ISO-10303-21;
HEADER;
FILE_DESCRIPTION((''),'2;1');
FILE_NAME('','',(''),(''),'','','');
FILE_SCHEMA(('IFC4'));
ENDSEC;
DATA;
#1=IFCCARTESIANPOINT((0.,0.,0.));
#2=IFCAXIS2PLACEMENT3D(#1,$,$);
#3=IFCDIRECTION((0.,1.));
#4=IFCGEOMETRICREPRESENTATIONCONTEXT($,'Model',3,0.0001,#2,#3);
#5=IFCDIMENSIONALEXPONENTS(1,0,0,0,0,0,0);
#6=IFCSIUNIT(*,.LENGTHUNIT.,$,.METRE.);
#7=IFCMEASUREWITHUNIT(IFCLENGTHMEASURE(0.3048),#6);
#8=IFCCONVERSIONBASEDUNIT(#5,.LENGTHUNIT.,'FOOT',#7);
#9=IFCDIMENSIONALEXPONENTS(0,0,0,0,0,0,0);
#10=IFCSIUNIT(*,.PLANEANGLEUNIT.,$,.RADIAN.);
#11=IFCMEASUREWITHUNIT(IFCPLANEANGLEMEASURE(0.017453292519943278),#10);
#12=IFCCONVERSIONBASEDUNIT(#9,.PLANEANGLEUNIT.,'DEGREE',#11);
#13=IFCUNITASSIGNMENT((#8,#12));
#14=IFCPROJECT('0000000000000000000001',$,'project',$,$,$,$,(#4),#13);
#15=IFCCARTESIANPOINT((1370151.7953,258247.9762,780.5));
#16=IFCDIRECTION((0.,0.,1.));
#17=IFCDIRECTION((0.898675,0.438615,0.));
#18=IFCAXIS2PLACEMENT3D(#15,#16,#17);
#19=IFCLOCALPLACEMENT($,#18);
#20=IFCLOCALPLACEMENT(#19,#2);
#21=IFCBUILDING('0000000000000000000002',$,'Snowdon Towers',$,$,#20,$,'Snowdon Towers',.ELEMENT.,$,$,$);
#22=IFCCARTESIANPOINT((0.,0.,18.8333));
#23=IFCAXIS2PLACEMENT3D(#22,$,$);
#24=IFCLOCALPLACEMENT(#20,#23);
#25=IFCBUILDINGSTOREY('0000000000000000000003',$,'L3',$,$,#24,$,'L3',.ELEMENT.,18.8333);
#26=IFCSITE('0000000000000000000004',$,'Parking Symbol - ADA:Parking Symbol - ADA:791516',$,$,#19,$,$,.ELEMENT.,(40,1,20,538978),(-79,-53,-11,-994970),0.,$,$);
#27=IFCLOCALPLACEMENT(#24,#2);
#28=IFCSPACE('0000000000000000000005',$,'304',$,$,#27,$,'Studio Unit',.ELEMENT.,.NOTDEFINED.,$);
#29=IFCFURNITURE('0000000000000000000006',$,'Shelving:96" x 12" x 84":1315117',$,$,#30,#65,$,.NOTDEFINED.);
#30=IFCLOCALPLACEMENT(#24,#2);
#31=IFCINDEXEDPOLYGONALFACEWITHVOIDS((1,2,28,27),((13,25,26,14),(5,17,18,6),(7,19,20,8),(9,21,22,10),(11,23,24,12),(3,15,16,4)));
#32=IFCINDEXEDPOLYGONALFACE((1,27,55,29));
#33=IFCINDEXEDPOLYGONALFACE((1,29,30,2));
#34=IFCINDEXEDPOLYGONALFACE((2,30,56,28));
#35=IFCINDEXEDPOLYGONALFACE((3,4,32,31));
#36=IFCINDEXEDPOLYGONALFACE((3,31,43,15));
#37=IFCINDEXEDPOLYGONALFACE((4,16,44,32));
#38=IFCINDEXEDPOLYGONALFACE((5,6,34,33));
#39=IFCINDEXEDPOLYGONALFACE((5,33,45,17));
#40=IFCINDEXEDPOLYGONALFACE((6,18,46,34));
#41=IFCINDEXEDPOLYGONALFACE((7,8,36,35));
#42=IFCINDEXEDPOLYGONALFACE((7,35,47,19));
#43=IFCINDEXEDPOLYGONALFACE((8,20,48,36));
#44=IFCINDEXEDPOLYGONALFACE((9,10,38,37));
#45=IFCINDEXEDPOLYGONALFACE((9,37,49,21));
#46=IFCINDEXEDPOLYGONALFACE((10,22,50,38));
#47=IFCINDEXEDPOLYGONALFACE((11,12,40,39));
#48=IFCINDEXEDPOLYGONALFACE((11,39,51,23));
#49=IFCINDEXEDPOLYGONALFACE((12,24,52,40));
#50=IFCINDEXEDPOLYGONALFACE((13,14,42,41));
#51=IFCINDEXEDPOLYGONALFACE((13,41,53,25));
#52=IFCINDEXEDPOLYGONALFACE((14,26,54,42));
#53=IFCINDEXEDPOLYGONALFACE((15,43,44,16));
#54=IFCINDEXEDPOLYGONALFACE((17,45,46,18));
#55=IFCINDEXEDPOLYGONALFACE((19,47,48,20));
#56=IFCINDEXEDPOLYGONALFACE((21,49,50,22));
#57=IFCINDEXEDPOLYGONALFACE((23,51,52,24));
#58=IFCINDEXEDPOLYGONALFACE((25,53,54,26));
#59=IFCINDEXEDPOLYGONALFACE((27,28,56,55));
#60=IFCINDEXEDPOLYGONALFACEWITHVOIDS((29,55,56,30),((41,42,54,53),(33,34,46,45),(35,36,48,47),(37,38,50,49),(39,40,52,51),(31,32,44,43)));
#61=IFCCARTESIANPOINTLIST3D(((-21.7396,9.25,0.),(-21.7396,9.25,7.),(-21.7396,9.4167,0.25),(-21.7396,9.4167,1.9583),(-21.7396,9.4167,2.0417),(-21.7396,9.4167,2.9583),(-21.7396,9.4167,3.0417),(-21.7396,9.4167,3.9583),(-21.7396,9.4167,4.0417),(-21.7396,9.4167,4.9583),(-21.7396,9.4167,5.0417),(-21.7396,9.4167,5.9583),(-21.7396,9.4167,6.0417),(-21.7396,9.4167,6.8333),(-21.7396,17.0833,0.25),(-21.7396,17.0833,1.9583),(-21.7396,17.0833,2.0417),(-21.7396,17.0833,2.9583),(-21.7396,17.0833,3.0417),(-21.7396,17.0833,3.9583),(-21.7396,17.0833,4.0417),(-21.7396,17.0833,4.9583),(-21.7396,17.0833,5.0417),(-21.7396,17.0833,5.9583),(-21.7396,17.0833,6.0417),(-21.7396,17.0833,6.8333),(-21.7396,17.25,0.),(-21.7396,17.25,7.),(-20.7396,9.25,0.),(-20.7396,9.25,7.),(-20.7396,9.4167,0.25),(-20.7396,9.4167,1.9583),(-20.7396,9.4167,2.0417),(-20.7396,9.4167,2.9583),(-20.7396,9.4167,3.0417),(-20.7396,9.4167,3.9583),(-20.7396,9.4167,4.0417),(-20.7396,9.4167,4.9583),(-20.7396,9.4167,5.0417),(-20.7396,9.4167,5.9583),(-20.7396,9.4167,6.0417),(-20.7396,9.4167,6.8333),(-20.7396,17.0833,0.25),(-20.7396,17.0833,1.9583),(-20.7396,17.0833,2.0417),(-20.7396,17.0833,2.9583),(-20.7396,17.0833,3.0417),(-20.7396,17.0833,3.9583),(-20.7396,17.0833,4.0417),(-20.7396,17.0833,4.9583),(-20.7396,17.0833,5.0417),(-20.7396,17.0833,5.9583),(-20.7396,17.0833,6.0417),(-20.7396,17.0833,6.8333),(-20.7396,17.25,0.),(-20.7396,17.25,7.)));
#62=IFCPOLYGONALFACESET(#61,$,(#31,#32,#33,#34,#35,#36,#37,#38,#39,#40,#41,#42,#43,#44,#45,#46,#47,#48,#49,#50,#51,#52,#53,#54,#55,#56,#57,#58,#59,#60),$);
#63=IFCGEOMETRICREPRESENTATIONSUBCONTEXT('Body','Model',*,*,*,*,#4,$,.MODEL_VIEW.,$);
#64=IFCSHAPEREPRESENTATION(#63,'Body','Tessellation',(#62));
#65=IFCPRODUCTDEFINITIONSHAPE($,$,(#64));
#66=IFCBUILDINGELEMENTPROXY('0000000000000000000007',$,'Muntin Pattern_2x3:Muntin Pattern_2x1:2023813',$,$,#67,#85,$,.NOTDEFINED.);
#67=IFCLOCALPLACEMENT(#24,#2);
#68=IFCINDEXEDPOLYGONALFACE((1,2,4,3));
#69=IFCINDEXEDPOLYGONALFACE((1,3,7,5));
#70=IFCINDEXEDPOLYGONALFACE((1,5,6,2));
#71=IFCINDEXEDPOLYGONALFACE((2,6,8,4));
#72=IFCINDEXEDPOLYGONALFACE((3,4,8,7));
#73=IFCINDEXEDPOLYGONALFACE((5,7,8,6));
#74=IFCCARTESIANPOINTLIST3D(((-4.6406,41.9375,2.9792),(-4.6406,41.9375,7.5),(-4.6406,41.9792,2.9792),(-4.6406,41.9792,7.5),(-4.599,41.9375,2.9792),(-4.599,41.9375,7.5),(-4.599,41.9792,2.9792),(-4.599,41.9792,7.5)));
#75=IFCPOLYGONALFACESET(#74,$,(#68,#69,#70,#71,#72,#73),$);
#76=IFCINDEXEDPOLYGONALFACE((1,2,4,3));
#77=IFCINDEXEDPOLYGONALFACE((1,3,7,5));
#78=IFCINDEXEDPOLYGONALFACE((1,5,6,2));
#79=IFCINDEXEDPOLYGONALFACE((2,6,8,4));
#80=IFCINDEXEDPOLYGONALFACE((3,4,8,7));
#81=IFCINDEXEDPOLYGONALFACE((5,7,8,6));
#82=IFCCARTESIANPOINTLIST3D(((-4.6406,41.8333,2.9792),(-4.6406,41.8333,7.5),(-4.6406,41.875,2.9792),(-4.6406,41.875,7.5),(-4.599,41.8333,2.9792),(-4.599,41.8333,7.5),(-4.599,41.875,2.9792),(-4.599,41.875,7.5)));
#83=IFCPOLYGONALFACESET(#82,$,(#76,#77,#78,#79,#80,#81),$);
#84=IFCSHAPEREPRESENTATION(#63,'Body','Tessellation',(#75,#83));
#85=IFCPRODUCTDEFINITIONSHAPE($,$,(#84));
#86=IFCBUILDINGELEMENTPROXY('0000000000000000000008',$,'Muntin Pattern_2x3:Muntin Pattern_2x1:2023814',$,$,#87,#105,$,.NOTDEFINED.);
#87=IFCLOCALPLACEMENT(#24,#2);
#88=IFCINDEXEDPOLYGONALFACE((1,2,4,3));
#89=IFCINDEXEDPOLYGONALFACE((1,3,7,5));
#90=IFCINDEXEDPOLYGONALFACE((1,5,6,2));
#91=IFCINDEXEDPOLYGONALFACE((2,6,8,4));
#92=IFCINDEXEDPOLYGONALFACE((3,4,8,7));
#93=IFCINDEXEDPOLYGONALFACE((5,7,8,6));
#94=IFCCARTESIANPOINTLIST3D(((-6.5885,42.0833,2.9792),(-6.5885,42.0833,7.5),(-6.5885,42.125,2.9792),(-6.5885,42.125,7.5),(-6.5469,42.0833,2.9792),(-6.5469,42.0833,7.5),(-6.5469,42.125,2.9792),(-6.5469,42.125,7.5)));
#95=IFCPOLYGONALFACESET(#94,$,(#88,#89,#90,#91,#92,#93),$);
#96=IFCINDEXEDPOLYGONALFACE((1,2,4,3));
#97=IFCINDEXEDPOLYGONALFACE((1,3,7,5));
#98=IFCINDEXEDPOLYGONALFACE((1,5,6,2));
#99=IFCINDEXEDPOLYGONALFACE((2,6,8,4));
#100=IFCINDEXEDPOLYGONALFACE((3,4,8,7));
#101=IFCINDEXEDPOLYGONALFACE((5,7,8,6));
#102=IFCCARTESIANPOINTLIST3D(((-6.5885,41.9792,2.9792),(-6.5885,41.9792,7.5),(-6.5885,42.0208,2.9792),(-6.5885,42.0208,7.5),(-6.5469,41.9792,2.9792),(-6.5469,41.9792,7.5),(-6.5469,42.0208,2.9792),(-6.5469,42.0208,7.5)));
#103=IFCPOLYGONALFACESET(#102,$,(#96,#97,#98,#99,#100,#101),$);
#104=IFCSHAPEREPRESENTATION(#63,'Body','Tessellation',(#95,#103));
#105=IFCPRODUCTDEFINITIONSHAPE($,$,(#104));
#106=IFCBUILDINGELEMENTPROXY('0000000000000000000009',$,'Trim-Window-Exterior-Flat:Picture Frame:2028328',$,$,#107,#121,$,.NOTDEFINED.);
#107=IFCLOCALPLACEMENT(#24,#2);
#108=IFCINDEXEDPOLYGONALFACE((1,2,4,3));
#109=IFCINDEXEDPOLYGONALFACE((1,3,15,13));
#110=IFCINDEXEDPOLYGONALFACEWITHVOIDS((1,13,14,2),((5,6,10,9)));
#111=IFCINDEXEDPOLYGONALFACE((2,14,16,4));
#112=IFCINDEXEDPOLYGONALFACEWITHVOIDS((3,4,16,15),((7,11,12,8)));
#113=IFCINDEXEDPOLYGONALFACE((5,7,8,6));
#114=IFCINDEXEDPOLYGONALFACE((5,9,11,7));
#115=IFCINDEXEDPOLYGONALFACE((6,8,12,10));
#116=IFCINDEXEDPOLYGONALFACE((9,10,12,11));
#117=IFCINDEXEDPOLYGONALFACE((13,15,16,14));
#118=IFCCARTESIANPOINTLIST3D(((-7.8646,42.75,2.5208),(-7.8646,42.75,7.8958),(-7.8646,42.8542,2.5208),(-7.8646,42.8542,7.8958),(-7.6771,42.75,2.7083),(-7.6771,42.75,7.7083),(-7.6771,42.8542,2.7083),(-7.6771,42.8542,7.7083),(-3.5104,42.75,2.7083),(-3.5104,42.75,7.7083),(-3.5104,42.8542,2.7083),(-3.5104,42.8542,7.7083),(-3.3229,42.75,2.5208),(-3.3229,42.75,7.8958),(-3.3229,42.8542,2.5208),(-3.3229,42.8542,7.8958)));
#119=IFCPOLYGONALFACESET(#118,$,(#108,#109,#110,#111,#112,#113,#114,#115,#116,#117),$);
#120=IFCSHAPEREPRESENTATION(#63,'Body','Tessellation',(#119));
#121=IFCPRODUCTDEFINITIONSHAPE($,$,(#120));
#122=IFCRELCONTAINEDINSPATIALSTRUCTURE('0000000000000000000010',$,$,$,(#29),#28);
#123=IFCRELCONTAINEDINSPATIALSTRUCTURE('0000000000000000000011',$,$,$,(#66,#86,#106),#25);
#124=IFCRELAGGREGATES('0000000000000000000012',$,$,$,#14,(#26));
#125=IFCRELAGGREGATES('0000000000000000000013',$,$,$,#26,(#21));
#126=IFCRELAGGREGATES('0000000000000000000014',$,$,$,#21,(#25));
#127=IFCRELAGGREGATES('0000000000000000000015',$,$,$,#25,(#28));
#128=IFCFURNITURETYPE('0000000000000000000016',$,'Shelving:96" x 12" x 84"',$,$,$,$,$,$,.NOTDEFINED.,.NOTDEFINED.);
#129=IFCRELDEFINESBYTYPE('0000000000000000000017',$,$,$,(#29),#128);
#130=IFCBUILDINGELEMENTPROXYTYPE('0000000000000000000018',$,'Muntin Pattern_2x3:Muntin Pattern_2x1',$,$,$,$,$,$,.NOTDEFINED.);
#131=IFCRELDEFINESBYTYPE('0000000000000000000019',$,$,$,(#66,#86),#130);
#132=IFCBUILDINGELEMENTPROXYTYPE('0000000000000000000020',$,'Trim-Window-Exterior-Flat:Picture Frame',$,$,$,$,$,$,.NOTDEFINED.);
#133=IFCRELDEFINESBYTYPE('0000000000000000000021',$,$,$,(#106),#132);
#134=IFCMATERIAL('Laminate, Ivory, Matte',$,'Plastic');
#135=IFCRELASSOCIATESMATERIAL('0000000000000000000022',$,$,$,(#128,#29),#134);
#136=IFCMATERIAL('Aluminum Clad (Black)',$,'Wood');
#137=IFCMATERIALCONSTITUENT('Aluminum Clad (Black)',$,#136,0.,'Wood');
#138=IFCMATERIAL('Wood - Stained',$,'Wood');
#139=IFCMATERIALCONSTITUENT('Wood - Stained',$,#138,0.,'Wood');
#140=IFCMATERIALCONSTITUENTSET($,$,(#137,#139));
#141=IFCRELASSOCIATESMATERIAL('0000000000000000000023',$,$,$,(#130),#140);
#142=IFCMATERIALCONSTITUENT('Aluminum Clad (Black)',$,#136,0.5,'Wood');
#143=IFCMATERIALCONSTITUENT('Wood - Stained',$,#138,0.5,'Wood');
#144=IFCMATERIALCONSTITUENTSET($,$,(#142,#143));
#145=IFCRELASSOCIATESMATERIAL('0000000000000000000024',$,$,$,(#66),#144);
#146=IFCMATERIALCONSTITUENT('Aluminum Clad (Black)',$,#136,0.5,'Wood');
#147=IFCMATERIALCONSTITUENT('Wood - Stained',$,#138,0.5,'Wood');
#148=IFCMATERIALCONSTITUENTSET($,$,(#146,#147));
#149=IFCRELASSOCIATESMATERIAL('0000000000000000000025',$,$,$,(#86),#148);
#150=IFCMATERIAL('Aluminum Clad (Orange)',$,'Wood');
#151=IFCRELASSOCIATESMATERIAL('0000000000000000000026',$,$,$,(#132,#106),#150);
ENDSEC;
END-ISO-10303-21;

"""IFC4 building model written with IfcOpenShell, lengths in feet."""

from ifc_helpers import new_model, entity, si_unit, converted_unit, direction, frame, origin, place, context, subcontext, project, spatial, indexed_curve, outline, extrude, source, transform, mapped, material, constituent, constituent_set, type_object, type_shapes, element, save


model = new_model("IFC4")

# Units and contexts
model_context = context("Model", 3, precision=0.0001, world=origin(), true_north=direction((0.0, 1.0)))
body_context = subcontext(model_context, "Body", "Model", "MODEL_VIEW")
ifc_project = project(units=[converted_unit("LENGTHUNIT", "FOOT", entity("IfcLengthMeasure", 0.3048), si_unit("LENGTHUNIT", "METRE"), dimensions=[1, 0, 0, 0, 0, 0, 0]), converted_unit("PLANEANGLEUNIT", "DEGREE", entity("IfcPlaneAngleMeasure", 0.017453292519943278), si_unit("PLANEANGLEUNIT", "RADIAN"), dimensions=[0, 0, 0, 0, 0, 0, 0])], contexts=[model_context])

# Site, building, storey
site_placement = place(None, frame((1370151.7953, 258247.9762, 780.5), z_axis=(0.0, 0.0, 1.0), x_axis=(0.898675, 0.438615, 0.0)))
site = spatial("IfcSite", under=ifc_project, at=site_placement, Name="Parking Symbol - ADA:Parking Symbol - ADA:791516", CompositionType="ELEMENT", RefLatitude=(40, 1, 20, 538978), RefLongitude=(-79, -53, -11, -994970), RefElevation=0.0)
building_placement = place(site_placement, origin())
building = spatial("IfcBuilding", under=site, at=building_placement, Name="Snowdon Towers", LongName="Snowdon Towers", CompositionType="ELEMENT")
storey_placement = place(building_placement, frame((0.0, 0.0, 18.8333)))
storey = spatial("IfcBuildingStorey", under=building, at=storey_placement, Name="L3", LongName="L3", CompositionType="ELEMENT", Elevation=18.8333)

# Shared definitions
space_placement = place(storey_placement, origin())
space = spatial("IfcSpace", under=storey, at=space_placement, Name="304", LongName="Studio Unit", CompositionType="ELEMENT", PredefinedType="NOTDEFINED")

# Furniture
ifc_material_1 = material(Name="Laminate, Ivory, Matte", Category="Plastic")
furniture_type = type_object("IfcFurnitureType", Name="Shelving:96\" x 12\" x 84\"", AssemblyPlace="NOTDEFINED", PredefinedType="NOTDEFINED", material=ifc_material_1)
shared_shape_1 = source(origin(), body_context, "Body", "SweptSolid", [
    extrude(outline(indexed_curve([(-4.0, -3.5), (4.0, -3.5), (4.0, 3.5), (-4.0, 3.5), (-4.0, -3.5)], self_intersect=False), holes=[indexed_curve([(-3.8333, 3.3333), (3.8333, 3.3333), (3.8333, 2.5417), (-3.8333, 2.5417), (-3.8333, 3.3333)], self_intersect=False), indexed_curve([(-3.8333, -3.25), (-3.8333, -1.5417), (3.8333, -1.5417), (3.8333, -3.25), (-3.8333, -3.25)], self_intersect=False), indexed_curve([(3.8333, 0.5417), (-3.8333, 0.5417), (-3.8333, 1.4583), (3.8333, 1.4583), (3.8333, 0.5417)], self_intersect=False), indexed_curve([(-3.8333, 2.4583), (3.8333, 2.4583), (3.8333, 1.5417), (-3.8333, 1.5417), (-3.8333, 2.4583)], self_intersect=False), indexed_curve([(-3.8333, 0.4583), (3.8333, 0.4583), (3.8333, -0.4583), (-3.8333, -0.4583), (-3.8333, 0.4583)], self_intersect=False), indexed_curve([(-3.8333, -0.5417), (3.8333, -0.5417), (3.8333, -1.4583), (-3.8333, -1.4583), (-3.8333, -0.5417)], self_intersect=False)]), frame((0.0, -1.5, 3.5), z_axis=(0.0, 1.0, 0.0), x_axis=(-1.0, 0.0, 0.0)), (0.0, 0.0, 1.0), 1.0),
])
type_shapes(furniture_type, [shared_shape_1])
furniture_placement = place(space_placement, frame((-22.2396, 13.25, 0.0), z_axis=(0.0, 0.0, 1.0), x_axis=(0.0, 1.0, 0.0)))
element("IfcFurniture", 1, at=furniture_placement, inside=space, type_object=furniture_type, material=ifc_material_1, Name="Shelving:96\" x 12\" x 84\":1315117", PredefinedType="NOTDEFINED", context=body_context, shape_type="MappedRepresentation", body=[
    mapped(shared_shape_1, transform((0.0, 0.0, 0.0), scale=1.0)),
])

# Building element proxies
ifc_material_2 = material(Name="Aluminum Clad (Black)", Category="Wood")
ifc_constituent_1 = constituent(ifc_material_2, Name="Aluminum Clad (Black)", Category="Wood", fraction=0.5)
ifc_material_3 = material(Name="Wood - Stained", Category="Wood")
ifc_constituent_2 = constituent(ifc_material_3, Name="Wood - Stained", Category="Wood", fraction=0.5)
ifc_constituent_set_1 = constituent_set(constituents=[ifc_constituent_1, ifc_constituent_2])
ifc_constituent_3 = constituent(ifc_material_2, Name="Aluminum Clad (Black)", Category="Wood", fraction=0.0)
ifc_constituent_4 = constituent(ifc_material_3, Name="Wood - Stained", Category="Wood", fraction=0.0)
ifc_constituent_set_2 = constituent_set(constituents=[ifc_constituent_3, ifc_constituent_4])
building_element_proxy_type_1 = type_object("IfcBuildingElementProxyType", Name="Muntin Pattern_2x3:Muntin Pattern_2x1", PredefinedType="NOTDEFINED", material=ifc_constituent_set_2)
shared_shape_2 = source(origin(), body_context, "Body", "SweptSolid", [
    extrude(outline(indexed_curve([(-0.0208, -0.0208), (0.0208, -0.0208), (0.0208, 0.0208), (-0.0208, 0.0208), (-0.0208, -0.0208)], self_intersect=False)), frame((0.0, 0.0521, 0.0), z_axis=(0.0, 0.0, 1.0), x_axis=(0.0, -1.0, 0.0)), (0.0, 0.0, 1.0), 4.5208),
    extrude(outline(indexed_curve([(-0.0208, -0.0208), (0.0208, -0.0208), (0.0208, 0.0208), (-0.0208, 0.0208), (-0.0208, -0.0208)], self_intersect=False)), frame((0.0, -0.0521, 0.0), z_axis=(0.0, 0.0, 1.0), x_axis=(0.0, -1.0, 0.0)), (0.0, 0.0, 1.0), 4.5208),
])
type_shapes(building_element_proxy_type_1, [shared_shape_2])
proxy_1_placement = place(storey_placement, frame((-4.6198, 41.9063, 2.9792)))
element("IfcBuildingElementProxy", 2, at=proxy_1_placement, inside=storey, type_object=building_element_proxy_type_1, material=ifc_constituent_set_1, Name="Muntin Pattern_2x3:Muntin Pattern_2x1:2023813", PredefinedType="NOTDEFINED", context=body_context, shape_type="MappedRepresentation", body=[
    mapped(shared_shape_2, transform((0.0, 0.0, 0.0), scale=1.0)),
])
ifc_constituent_5 = constituent(ifc_material_2, Name="Aluminum Clad (Black)", Category="Wood", fraction=0.5)
ifc_constituent_6 = constituent(ifc_material_3, Name="Wood - Stained", Category="Wood", fraction=0.5)
ifc_constituent_set_3 = constituent_set(constituents=[ifc_constituent_5, ifc_constituent_6])
proxy_2_placement = place(storey_placement, frame((-6.5677, 42.0521, 2.9792)))
element("IfcBuildingElementProxy", 3, at=proxy_2_placement, inside=storey, type_object=building_element_proxy_type_1, material=ifc_constituent_set_3, Name="Muntin Pattern_2x3:Muntin Pattern_2x1:2023814", PredefinedType="NOTDEFINED", context=body_context, shape_type="MappedRepresentation", body=[
    mapped(shared_shape_2, transform((0.0, 0.0, 0.0), scale=1.0)),
])
ifc_material_4 = material(Name="Aluminum Clad (Orange)", Category="Wood")
building_element_proxy_type_2 = type_object("IfcBuildingElementProxyType", Name="Trim-Window-Exterior-Flat:Picture Frame", PredefinedType="NOTDEFINED", material=ifc_material_4)
shared_shape_3 = source(origin(), body_context, "Body", "SweptSolid", [
    extrude(outline(indexed_curve([(-2.2708, -2.6875), (2.2708, -2.6875), (2.2708, 2.6875), (-2.2708, 2.6875), (-2.2708, -2.6875)], self_intersect=False), holes=[indexed_curve([(-2.0833, -2.5), (-2.0833, 2.5), (2.0833, 2.5), (2.0833, -2.5), (-2.0833, -2.5)], self_intersect=False)]), frame((0.0, -2.5, 0.0), z_axis=(0.0, 0.0, 1.0), x_axis=(-1.0, 0.0, 0.0)), (0.0, 0.0, 1.0), 0.1042),
])
type_shapes(building_element_proxy_type_2, [shared_shape_3])
proxy_3_placement = place(storey_placement, frame((-5.5937, 42.75, 7.7083), z_axis=(0.0, 1.0, 0.0), x_axis=(-1.0, 0.0, 0.0)))
element("IfcBuildingElementProxy", 4, at=proxy_3_placement, inside=storey, type_object=building_element_proxy_type_2, material=ifc_material_4, Name="Trim-Window-Exterior-Flat:Picture Frame:2028328", PredefinedType="NOTDEFINED", context=body_context, shape_type="MappedRepresentation", body=[
    mapped(shared_shape_3, transform((0.0, 0.0, 0.0), scale=1.0)),
])

save(model, "model.ifc")
